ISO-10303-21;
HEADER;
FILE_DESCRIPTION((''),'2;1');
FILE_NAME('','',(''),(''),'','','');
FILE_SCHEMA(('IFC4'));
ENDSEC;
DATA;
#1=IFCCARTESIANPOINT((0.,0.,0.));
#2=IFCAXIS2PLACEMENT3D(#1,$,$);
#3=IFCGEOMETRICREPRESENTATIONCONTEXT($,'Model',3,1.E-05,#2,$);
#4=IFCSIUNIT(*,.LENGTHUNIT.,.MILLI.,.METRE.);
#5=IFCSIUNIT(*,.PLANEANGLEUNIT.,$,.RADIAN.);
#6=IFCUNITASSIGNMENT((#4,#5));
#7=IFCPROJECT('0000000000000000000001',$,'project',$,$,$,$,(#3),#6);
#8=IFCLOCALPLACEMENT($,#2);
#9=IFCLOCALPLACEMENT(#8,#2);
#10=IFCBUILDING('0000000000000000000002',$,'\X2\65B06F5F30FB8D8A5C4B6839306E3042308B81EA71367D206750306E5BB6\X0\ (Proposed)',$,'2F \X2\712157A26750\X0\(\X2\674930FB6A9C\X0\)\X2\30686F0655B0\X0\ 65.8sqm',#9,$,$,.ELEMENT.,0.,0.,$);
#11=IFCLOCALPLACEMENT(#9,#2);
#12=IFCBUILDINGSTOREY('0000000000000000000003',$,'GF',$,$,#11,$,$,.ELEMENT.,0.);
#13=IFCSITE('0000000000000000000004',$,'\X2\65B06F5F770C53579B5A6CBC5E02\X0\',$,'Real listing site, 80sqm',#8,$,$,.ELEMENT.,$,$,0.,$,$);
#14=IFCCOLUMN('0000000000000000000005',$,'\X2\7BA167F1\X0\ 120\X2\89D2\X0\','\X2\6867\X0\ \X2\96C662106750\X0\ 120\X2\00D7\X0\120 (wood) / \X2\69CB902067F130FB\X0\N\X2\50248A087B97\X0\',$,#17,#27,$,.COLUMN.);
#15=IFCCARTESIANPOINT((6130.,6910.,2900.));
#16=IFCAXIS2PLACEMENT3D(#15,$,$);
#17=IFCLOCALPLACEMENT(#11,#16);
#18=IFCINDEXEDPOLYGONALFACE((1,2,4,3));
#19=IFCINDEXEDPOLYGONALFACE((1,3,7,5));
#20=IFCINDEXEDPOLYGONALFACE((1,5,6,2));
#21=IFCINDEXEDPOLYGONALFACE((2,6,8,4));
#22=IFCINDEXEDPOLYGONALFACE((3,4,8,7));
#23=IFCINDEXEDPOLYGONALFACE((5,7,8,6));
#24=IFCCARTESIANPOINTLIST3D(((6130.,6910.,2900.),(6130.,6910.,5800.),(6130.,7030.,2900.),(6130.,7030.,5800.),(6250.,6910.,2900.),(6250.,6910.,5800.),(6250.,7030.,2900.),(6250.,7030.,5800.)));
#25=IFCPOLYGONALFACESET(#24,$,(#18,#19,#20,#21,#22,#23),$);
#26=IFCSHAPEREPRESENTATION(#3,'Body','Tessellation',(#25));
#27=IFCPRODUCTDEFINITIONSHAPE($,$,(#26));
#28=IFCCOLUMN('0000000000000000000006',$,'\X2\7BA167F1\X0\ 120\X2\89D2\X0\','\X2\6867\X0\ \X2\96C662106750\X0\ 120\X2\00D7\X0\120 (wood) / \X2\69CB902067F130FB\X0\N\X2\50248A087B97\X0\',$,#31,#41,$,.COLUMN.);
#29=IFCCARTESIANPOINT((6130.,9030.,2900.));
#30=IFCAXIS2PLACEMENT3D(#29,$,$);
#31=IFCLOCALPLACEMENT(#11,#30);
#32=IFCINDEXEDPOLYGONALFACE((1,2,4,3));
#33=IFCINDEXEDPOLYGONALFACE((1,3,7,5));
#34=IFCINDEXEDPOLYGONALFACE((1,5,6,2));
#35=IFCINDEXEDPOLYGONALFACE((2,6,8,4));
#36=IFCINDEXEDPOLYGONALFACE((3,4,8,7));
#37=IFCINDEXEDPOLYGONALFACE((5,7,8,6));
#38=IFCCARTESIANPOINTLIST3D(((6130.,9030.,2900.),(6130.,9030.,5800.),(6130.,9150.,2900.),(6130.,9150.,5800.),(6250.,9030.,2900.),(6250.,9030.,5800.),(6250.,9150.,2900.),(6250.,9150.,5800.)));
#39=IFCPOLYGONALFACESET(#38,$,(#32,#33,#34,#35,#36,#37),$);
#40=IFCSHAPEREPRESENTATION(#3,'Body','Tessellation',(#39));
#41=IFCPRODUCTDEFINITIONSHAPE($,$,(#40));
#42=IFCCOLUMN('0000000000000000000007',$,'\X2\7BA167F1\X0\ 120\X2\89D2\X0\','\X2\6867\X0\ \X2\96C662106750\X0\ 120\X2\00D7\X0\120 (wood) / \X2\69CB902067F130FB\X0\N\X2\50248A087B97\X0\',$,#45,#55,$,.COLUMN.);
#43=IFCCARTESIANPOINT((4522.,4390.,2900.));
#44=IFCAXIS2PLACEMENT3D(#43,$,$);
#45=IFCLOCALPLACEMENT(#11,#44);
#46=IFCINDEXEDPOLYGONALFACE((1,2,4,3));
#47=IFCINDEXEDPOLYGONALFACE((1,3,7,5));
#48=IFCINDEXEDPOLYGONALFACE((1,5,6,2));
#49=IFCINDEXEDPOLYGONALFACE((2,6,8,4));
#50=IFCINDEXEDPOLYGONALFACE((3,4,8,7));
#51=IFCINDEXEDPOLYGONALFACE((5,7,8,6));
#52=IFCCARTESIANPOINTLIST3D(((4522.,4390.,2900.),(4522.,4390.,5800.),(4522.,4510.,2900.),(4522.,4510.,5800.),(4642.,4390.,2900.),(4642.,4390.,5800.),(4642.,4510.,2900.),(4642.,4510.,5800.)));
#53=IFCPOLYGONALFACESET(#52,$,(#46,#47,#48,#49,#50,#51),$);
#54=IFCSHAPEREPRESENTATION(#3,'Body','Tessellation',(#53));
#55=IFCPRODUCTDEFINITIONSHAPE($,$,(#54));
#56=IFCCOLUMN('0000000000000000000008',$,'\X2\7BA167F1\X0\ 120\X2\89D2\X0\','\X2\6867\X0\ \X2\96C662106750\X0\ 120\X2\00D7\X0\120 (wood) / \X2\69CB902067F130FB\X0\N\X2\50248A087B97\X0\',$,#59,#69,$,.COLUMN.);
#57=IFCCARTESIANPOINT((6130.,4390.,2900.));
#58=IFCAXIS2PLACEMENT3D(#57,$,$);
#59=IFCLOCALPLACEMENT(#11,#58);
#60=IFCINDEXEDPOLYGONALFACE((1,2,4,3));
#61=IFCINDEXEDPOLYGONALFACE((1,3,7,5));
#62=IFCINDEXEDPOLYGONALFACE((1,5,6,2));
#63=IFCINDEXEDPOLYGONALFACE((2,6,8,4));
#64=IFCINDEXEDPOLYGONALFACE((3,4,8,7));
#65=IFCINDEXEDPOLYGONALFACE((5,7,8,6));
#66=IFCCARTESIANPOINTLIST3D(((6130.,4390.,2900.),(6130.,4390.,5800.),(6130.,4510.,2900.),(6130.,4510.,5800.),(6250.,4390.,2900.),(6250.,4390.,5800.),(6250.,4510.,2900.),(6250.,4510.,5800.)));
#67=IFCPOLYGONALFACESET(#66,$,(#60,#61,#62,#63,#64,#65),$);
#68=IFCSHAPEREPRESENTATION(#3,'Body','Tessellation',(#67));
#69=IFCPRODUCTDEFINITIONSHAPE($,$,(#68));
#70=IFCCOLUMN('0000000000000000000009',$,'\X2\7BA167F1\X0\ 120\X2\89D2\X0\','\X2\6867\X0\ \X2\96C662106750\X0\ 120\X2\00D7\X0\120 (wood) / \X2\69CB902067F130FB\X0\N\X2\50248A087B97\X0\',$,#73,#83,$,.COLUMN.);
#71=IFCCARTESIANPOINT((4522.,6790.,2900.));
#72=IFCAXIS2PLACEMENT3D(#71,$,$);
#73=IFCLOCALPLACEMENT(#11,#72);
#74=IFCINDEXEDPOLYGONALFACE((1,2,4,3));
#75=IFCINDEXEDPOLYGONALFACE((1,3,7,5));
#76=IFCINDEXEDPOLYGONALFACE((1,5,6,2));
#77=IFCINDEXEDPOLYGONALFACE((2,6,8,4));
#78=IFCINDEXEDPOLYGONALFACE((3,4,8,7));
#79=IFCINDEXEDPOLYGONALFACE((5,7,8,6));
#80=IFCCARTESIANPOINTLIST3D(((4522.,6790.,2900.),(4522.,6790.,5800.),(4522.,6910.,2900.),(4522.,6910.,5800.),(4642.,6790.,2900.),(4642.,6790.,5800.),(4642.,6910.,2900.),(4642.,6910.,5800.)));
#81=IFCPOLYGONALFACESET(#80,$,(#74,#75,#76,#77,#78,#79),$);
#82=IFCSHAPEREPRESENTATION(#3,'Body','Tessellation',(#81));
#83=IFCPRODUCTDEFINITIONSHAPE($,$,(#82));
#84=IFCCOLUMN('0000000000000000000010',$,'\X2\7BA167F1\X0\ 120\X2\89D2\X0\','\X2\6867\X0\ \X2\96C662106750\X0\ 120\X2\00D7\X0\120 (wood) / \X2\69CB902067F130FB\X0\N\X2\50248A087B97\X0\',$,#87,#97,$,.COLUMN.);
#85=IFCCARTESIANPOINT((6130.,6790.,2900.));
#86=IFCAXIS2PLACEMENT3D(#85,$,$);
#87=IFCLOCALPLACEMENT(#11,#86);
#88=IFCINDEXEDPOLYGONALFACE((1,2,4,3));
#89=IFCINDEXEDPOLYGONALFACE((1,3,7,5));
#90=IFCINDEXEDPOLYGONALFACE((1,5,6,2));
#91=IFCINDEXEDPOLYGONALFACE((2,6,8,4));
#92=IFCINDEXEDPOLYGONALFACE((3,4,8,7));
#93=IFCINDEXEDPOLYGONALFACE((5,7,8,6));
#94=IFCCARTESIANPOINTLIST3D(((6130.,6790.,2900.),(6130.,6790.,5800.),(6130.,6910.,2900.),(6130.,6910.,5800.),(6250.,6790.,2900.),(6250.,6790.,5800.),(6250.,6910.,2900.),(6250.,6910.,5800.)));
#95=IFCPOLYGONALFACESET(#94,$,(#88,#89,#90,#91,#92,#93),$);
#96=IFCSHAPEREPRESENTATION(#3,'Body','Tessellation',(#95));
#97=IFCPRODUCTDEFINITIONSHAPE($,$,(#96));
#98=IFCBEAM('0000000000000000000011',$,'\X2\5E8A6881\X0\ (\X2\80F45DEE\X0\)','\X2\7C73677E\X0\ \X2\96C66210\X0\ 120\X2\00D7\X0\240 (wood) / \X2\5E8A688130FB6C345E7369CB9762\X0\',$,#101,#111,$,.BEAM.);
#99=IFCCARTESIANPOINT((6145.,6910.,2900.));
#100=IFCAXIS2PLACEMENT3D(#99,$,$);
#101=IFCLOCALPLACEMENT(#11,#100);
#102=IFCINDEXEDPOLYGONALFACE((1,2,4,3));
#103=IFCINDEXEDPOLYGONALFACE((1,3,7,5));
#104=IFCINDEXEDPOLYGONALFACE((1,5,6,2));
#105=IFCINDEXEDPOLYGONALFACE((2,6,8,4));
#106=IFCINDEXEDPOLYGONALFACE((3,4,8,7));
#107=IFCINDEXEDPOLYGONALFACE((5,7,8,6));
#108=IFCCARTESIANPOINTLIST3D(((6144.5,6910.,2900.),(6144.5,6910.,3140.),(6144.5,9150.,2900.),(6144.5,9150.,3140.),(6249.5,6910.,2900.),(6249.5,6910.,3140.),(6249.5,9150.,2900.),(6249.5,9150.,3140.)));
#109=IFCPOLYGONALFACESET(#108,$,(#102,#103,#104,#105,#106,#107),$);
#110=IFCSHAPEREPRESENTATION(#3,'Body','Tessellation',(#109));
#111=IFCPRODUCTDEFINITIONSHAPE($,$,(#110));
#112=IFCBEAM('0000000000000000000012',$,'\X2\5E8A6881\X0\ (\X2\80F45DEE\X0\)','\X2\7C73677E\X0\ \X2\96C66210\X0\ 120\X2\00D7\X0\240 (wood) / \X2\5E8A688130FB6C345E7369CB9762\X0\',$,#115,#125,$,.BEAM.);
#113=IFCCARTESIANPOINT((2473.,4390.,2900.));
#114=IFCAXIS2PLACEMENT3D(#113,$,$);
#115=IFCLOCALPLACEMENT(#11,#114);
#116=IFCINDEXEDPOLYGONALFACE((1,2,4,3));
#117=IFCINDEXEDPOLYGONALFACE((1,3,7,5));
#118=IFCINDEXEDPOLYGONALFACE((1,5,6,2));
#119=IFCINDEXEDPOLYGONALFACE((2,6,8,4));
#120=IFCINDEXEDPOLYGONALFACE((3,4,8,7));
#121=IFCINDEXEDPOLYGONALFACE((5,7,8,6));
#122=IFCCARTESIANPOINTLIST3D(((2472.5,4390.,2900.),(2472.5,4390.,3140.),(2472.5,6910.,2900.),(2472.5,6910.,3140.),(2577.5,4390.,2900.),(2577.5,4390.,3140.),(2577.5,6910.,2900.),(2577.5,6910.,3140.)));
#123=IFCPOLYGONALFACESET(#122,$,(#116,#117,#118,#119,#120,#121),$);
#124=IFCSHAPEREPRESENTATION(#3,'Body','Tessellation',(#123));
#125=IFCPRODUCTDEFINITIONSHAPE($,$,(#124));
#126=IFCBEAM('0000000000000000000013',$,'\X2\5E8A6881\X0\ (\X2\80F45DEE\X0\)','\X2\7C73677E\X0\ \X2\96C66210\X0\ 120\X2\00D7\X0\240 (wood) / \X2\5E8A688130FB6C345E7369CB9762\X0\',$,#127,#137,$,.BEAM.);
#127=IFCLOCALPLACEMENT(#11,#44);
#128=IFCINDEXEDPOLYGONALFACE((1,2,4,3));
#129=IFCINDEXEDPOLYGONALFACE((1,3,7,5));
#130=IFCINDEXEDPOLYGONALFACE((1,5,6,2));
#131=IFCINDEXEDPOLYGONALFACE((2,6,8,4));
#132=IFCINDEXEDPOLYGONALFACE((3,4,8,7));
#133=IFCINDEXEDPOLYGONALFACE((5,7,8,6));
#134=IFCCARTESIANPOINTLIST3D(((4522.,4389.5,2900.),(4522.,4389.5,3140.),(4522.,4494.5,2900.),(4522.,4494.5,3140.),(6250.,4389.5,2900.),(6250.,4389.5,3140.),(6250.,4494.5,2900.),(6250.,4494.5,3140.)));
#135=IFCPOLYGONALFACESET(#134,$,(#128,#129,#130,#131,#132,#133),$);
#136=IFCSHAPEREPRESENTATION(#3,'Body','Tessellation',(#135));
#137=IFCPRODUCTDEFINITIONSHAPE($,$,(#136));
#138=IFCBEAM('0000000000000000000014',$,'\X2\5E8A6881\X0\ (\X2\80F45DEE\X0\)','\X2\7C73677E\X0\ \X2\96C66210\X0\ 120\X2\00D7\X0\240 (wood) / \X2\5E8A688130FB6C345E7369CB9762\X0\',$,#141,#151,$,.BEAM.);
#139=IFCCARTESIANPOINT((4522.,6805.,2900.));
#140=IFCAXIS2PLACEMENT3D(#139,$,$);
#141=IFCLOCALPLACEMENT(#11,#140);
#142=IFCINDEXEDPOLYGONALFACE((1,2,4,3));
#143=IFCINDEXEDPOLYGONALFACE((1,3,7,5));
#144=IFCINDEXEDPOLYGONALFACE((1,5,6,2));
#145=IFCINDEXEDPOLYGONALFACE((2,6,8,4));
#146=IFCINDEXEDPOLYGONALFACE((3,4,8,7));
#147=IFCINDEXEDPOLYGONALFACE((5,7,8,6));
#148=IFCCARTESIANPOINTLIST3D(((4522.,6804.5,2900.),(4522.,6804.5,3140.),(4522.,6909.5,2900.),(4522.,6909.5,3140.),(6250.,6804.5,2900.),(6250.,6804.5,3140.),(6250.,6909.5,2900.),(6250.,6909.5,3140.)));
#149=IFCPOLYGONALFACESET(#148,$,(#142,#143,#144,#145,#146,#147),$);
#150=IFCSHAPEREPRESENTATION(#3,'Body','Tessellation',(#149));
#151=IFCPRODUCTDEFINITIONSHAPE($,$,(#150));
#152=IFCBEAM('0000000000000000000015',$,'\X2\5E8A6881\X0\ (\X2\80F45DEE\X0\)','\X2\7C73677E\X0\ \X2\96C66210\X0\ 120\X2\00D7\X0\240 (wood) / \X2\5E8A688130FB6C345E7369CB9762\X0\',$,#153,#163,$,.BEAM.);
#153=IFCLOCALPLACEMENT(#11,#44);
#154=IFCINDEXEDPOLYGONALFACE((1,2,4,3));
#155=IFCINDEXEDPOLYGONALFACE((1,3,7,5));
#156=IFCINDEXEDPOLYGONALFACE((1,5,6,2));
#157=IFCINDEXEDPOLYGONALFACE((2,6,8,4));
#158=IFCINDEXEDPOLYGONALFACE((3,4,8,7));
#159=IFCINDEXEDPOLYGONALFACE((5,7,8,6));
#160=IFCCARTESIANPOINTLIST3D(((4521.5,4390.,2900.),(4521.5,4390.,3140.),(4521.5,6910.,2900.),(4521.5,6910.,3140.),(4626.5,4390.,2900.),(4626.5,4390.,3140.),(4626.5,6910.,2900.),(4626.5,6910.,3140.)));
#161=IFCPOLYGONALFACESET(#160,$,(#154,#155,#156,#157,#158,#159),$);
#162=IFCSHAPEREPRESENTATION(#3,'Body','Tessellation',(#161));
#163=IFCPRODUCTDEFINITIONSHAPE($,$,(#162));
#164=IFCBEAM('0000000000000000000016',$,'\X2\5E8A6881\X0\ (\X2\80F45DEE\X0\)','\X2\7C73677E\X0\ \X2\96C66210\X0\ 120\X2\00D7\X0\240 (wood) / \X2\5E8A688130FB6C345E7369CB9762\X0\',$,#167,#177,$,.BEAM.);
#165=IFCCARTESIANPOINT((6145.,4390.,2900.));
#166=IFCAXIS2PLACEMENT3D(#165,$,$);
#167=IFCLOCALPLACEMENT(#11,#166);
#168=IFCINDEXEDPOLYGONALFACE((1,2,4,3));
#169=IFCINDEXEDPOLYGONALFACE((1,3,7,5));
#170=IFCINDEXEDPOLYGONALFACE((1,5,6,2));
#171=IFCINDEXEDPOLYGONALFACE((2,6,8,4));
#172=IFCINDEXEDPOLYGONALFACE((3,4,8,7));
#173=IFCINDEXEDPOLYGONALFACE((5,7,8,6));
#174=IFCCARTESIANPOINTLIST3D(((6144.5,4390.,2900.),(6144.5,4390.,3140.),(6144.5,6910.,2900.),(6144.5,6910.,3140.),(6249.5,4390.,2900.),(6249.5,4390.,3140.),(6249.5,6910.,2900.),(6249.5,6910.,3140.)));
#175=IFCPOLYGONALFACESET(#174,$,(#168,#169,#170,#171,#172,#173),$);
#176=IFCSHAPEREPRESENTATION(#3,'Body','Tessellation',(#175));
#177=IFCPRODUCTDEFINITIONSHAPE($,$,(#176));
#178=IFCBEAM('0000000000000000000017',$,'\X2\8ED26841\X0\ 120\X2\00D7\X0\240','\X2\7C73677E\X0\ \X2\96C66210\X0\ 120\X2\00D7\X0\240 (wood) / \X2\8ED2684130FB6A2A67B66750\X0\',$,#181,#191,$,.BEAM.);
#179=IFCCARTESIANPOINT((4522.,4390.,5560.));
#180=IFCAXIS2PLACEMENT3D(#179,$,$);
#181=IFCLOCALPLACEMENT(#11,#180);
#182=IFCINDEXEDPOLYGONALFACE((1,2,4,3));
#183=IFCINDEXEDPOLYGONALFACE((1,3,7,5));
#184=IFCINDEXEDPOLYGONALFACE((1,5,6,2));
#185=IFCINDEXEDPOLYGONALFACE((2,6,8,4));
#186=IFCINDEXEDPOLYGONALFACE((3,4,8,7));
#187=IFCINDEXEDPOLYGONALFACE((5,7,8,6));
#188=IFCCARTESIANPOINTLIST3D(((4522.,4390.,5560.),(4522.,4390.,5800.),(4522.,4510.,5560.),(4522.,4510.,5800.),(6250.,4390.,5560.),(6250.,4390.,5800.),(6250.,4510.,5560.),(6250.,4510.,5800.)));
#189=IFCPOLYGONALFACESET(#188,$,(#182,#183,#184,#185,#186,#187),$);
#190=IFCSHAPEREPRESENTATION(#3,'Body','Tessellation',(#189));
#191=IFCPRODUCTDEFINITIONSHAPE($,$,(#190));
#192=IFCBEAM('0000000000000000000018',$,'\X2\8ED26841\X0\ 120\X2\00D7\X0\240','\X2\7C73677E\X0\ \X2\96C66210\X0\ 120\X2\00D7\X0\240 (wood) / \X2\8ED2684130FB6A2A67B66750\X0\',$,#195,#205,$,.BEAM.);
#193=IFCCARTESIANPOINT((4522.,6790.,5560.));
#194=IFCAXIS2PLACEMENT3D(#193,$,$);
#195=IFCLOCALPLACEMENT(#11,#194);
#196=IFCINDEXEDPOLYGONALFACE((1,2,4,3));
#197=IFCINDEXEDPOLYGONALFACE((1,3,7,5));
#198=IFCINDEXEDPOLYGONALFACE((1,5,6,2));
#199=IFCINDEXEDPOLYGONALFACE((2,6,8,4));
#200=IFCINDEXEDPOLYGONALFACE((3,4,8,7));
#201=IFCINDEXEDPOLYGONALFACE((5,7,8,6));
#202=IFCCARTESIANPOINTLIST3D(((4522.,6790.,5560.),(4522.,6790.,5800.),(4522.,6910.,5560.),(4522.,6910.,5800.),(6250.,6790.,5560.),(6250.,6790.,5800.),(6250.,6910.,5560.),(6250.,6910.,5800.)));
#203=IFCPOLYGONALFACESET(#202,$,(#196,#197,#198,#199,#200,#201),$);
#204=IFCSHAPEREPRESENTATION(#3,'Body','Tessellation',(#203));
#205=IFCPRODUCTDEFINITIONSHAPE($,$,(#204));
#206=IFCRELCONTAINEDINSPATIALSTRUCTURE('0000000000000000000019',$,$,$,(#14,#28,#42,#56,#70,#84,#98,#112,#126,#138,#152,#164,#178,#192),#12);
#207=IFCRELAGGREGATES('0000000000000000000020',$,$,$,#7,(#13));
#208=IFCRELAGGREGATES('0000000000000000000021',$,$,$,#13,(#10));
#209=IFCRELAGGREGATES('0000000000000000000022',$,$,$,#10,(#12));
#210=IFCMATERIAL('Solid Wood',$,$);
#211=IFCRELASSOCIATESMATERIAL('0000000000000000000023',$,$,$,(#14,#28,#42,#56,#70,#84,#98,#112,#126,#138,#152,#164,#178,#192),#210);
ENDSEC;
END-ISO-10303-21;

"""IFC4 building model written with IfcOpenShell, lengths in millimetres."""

from ifc_helpers import new_model, si_unit, frame, frame_2d, origin, place, context, project, spatial, rectangle, extrude, material, element, save


model = new_model("IFC4")

# Units and contexts
model_context = context("Model", 3, precision=1e-05, world=origin())
ifc_project = project(units=[si_unit("LENGTHUNIT", "METRE", prefix="MILLI"), si_unit("PLANEANGLEUNIT", "RADIAN")], contexts=[model_context])

# Site, building, storey
site_placement = place(None, origin())
site = spatial("IfcSite", under=ifc_project, at=site_placement, Name="新潟県南魚沼市", ObjectType="Real listing site, 80sqm", CompositionType="ELEMENT", RefElevation=0.0)
building_placement = place(site_placement, origin())
building = spatial("IfcBuilding", under=site, at=building_placement, Name="新潟・越屋根のある自然素材の家 (Proposed)", ObjectType="2F 無垢材(杉・檜)と漆喰 65.8sqm", CompositionType="ELEMENT", ElevationOfRefHeight=0.0, ElevationOfTerrain=0.0)
storey_placement = place(building_placement, origin())
storey = spatial("IfcBuildingStorey", under=building, at=storey_placement, Name="GF", CompositionType="ELEMENT", Elevation=0.0)

# Columns
ifc_material_1 = material(Name="Solid Wood")
column_1_placement = place(storey_placement, frame((6130.0, 6910.0, 2900.0)))
element("IfcColumn", 1, at=column_1_placement, inside=storey, material=ifc_material_1, Name="管柱 120角", Description="桧 集成材 120×120 (wood) / 構造柱・N値計算", PredefinedType="COLUMN", context=model_context, shape_type="SweptSolid", body=[
    extrude(rectangle(XDim=120.0, YDim=120.0, at=frame_2d((60.0, 60.0))), frame((6130.0, 6910.0, 2900.0)), (0.0, 0.0, 1.0), 2900.0),
])
column_2_placement = place(storey_placement, frame((6130.0, 9030.0, 2900.0)))
element("IfcColumn", 2, at=column_2_placement, inside=storey, material=ifc_material_1, Name="管柱 120角", Description="桧 集成材 120×120 (wood) / 構造柱・N値計算", PredefinedType="COLUMN", context=model_context, shape_type="SweptSolid", body=[
    extrude(rectangle(XDim=120.0, YDim=120.0, at=frame_2d((60.0, 60.0))), frame((6130.0, 9030.0, 2900.0)), (0.0, 0.0, 1.0), 2900.0),
])
column_3_placement = place(storey_placement, frame((4522.0, 4390.0, 2900.0)))
element("IfcColumn", 3, at=column_3_placement, inside=storey, material=ifc_material_1, Name="管柱 120角", Description="桧 集成材 120×120 (wood) / 構造柱・N値計算", PredefinedType="COLUMN", context=model_context, shape_type="SweptSolid", body=[
    extrude(rectangle(XDim=120.0, YDim=120.0, at=frame_2d((60.0, 60.0))), frame((4522.0, 4390.0, 2900.0)), (0.0, 0.0, 1.0), 2900.0),
])
column_4_placement = place(storey_placement, frame((6130.0, 4390.0, 2900.0)))
element("IfcColumn", 4, at=column_4_placement, inside=storey, material=ifc_material_1, Name="管柱 120角", Description="桧 集成材 120×120 (wood) / 構造柱・N値計算", PredefinedType="COLUMN", context=model_context, shape_type="SweptSolid", body=[
    extrude(rectangle(XDim=120.0, YDim=120.0, at=frame_2d((60.0, 60.0))), frame((6130.0, 4390.0, 2900.0)), (0.0, 0.0, 1.0), 2900.0),
])
column_5_placement = place(storey_placement, frame((4522.0, 6790.0, 2900.0)))
element("IfcColumn", 5, at=column_5_placement, inside=storey, material=ifc_material_1, Name="管柱 120角", Description="桧 集成材 120×120 (wood) / 構造柱・N値計算", PredefinedType="COLUMN", context=model_context, shape_type="SweptSolid", body=[
    extrude(rectangle(XDim=120.0, YDim=120.0, at=frame_2d((60.0, 60.0))), frame((4522.0, 6790.0, 2900.0)), (0.0, 0.0, 1.0), 2900.0),
])
column_6_placement = place(storey_placement, frame((6130.0, 6790.0, 2900.0)))
element("IfcColumn", 6, at=column_6_placement, inside=storey, material=ifc_material_1, Name="管柱 120角", Description="桧 集成材 120×120 (wood) / 構造柱・N値計算", PredefinedType="COLUMN", context=model_context, shape_type="SweptSolid", body=[
    extrude(rectangle(XDim=120.0, YDim=120.0, at=frame_2d((60.0, 60.0))), frame((6130.0, 6790.0, 2900.0)), (0.0, 0.0, 1.0), 2900.0),
])

# Beams
beam_1_placement = place(storey_placement, frame((6145.0, 6910.0, 2900.0)))
element("IfcBeam", 7, at=beam_1_placement, inside=storey, material=ifc_material_1, Name="床梁 (胴差)", Description="米松 集成 120×240 (wood) / 床梁・水平構面", PredefinedType="BEAM", context=model_context, shape_type="SweptSolid", body=[
    extrude(rectangle(XDim=105.0, YDim=2240.0, at=frame_2d((52.0, 1120.0))), frame((6145.0, 6910.0, 2900.0)), (0.0, 0.0, 1.0), 240.0),
])
beam_2_placement = place(storey_placement, frame((2473.0, 4390.0, 2900.0)))
element("IfcBeam", 8, at=beam_2_placement, inside=storey, material=ifc_material_1, Name="床梁 (胴差)", Description="米松 集成 120×240 (wood) / 床梁・水平構面", PredefinedType="BEAM", context=model_context, shape_type="SweptSolid", body=[
    extrude(rectangle(XDim=105.0, YDim=2520.0, at=frame_2d((52.0, 1260.0))), frame((2473.0, 4390.0, 2900.0)), (0.0, 0.0, 1.0), 240.0),
])
beam_3_placement = place(storey_placement, frame((4522.0, 4390.0, 2900.0)))
element("IfcBeam", 9, at=beam_3_placement, inside=storey, material=ifc_material_1, Name="床梁 (胴差)", Description="米松 集成 120×240 (wood) / 床梁・水平構面", PredefinedType="BEAM", context=model_context, shape_type="SweptSolid", body=[
    extrude(rectangle(XDim=1728.0, YDim=105.0, at=frame_2d((864.0, 52.0))), frame((4522.0, 4390.0, 2900.0)), (0.0, 0.0, 1.0), 240.0),
])
beam_4_placement = place(storey_placement, frame((4522.0, 6805.0, 2900.0)))
element("IfcBeam", 10, at=beam_4_placement, inside=storey, material=ifc_material_1, Name="床梁 (胴差)", Description="米松 集成 120×240 (wood) / 床梁・水平構面", PredefinedType="BEAM", context=model_context, shape_type="SweptSolid", body=[
    extrude(rectangle(XDim=1728.0, YDim=105.0, at=frame_2d((864.0, 52.0))), frame((4522.0, 6805.0, 2900.0)), (0.0, 0.0, 1.0), 240.0),
])
beam_5_placement = place(storey_placement, frame((4522.0, 4390.0, 2900.0)))
element("IfcBeam", 11, at=beam_5_placement, inside=storey, material=ifc_material_1, Name="床梁 (胴差)", Description="米松 集成 120×240 (wood) / 床梁・水平構面", PredefinedType="BEAM", context=model_context, shape_type="SweptSolid", body=[
    extrude(rectangle(XDim=105.0, YDim=2520.0, at=frame_2d((52.0, 1260.0))), frame((4522.0, 4390.0, 2900.0)), (0.0, 0.0, 1.0), 240.0),
])
beam_6_placement = place(storey_placement, frame((6145.0, 4390.0, 2900.0)))
element("IfcBeam", 12, at=beam_6_placement, inside=storey, material=ifc_material_1, Name="床梁 (胴差)", Description="米松 集成 120×240 (wood) / 床梁・水平構面", PredefinedType="BEAM", context=model_context, shape_type="SweptSolid", body=[
    extrude(rectangle(XDim=105.0, YDim=2520.0, at=frame_2d((52.0, 1260.0))), frame((6145.0, 4390.0, 2900.0)), (0.0, 0.0, 1.0), 240.0),
])
beam_7_placement = place(storey_placement, frame((4522.0, 4390.0, 5560.0)))
element("IfcBeam", 13, at=beam_7_placement, inside=storey, material=ifc_material_1, Name="軒桁 120×240", Description="米松 集成 120×240 (wood) / 軒桁・横架材", PredefinedType="BEAM", context=model_context, shape_type="SweptSolid", body=[
    extrude(rectangle(XDim=1728.0, YDim=120.0, at=frame_2d((864.0, 60.0))), frame((4522.0, 4390.0, 5560.0)), (0.0, 0.0, 1.0), 240.0),
])
beam_8_placement = place(storey_placement, frame((4522.0, 6790.0, 5560.0)))
element("IfcBeam", 14, at=beam_8_placement, inside=storey, material=ifc_material_1, Name="軒桁 120×240", Description="米松 集成 120×240 (wood) / 軒桁・横架材", PredefinedType="BEAM", context=model_context, shape_type="SweptSolid", body=[
    extrude(rectangle(XDim=1728.0, YDim=120.0, at=frame_2d((864.0, 60.0))), frame((4522.0, 6790.0, 5560.0)), (0.0, 0.0, 1.0), 240.0),
])

save(model, "model.ifc")
